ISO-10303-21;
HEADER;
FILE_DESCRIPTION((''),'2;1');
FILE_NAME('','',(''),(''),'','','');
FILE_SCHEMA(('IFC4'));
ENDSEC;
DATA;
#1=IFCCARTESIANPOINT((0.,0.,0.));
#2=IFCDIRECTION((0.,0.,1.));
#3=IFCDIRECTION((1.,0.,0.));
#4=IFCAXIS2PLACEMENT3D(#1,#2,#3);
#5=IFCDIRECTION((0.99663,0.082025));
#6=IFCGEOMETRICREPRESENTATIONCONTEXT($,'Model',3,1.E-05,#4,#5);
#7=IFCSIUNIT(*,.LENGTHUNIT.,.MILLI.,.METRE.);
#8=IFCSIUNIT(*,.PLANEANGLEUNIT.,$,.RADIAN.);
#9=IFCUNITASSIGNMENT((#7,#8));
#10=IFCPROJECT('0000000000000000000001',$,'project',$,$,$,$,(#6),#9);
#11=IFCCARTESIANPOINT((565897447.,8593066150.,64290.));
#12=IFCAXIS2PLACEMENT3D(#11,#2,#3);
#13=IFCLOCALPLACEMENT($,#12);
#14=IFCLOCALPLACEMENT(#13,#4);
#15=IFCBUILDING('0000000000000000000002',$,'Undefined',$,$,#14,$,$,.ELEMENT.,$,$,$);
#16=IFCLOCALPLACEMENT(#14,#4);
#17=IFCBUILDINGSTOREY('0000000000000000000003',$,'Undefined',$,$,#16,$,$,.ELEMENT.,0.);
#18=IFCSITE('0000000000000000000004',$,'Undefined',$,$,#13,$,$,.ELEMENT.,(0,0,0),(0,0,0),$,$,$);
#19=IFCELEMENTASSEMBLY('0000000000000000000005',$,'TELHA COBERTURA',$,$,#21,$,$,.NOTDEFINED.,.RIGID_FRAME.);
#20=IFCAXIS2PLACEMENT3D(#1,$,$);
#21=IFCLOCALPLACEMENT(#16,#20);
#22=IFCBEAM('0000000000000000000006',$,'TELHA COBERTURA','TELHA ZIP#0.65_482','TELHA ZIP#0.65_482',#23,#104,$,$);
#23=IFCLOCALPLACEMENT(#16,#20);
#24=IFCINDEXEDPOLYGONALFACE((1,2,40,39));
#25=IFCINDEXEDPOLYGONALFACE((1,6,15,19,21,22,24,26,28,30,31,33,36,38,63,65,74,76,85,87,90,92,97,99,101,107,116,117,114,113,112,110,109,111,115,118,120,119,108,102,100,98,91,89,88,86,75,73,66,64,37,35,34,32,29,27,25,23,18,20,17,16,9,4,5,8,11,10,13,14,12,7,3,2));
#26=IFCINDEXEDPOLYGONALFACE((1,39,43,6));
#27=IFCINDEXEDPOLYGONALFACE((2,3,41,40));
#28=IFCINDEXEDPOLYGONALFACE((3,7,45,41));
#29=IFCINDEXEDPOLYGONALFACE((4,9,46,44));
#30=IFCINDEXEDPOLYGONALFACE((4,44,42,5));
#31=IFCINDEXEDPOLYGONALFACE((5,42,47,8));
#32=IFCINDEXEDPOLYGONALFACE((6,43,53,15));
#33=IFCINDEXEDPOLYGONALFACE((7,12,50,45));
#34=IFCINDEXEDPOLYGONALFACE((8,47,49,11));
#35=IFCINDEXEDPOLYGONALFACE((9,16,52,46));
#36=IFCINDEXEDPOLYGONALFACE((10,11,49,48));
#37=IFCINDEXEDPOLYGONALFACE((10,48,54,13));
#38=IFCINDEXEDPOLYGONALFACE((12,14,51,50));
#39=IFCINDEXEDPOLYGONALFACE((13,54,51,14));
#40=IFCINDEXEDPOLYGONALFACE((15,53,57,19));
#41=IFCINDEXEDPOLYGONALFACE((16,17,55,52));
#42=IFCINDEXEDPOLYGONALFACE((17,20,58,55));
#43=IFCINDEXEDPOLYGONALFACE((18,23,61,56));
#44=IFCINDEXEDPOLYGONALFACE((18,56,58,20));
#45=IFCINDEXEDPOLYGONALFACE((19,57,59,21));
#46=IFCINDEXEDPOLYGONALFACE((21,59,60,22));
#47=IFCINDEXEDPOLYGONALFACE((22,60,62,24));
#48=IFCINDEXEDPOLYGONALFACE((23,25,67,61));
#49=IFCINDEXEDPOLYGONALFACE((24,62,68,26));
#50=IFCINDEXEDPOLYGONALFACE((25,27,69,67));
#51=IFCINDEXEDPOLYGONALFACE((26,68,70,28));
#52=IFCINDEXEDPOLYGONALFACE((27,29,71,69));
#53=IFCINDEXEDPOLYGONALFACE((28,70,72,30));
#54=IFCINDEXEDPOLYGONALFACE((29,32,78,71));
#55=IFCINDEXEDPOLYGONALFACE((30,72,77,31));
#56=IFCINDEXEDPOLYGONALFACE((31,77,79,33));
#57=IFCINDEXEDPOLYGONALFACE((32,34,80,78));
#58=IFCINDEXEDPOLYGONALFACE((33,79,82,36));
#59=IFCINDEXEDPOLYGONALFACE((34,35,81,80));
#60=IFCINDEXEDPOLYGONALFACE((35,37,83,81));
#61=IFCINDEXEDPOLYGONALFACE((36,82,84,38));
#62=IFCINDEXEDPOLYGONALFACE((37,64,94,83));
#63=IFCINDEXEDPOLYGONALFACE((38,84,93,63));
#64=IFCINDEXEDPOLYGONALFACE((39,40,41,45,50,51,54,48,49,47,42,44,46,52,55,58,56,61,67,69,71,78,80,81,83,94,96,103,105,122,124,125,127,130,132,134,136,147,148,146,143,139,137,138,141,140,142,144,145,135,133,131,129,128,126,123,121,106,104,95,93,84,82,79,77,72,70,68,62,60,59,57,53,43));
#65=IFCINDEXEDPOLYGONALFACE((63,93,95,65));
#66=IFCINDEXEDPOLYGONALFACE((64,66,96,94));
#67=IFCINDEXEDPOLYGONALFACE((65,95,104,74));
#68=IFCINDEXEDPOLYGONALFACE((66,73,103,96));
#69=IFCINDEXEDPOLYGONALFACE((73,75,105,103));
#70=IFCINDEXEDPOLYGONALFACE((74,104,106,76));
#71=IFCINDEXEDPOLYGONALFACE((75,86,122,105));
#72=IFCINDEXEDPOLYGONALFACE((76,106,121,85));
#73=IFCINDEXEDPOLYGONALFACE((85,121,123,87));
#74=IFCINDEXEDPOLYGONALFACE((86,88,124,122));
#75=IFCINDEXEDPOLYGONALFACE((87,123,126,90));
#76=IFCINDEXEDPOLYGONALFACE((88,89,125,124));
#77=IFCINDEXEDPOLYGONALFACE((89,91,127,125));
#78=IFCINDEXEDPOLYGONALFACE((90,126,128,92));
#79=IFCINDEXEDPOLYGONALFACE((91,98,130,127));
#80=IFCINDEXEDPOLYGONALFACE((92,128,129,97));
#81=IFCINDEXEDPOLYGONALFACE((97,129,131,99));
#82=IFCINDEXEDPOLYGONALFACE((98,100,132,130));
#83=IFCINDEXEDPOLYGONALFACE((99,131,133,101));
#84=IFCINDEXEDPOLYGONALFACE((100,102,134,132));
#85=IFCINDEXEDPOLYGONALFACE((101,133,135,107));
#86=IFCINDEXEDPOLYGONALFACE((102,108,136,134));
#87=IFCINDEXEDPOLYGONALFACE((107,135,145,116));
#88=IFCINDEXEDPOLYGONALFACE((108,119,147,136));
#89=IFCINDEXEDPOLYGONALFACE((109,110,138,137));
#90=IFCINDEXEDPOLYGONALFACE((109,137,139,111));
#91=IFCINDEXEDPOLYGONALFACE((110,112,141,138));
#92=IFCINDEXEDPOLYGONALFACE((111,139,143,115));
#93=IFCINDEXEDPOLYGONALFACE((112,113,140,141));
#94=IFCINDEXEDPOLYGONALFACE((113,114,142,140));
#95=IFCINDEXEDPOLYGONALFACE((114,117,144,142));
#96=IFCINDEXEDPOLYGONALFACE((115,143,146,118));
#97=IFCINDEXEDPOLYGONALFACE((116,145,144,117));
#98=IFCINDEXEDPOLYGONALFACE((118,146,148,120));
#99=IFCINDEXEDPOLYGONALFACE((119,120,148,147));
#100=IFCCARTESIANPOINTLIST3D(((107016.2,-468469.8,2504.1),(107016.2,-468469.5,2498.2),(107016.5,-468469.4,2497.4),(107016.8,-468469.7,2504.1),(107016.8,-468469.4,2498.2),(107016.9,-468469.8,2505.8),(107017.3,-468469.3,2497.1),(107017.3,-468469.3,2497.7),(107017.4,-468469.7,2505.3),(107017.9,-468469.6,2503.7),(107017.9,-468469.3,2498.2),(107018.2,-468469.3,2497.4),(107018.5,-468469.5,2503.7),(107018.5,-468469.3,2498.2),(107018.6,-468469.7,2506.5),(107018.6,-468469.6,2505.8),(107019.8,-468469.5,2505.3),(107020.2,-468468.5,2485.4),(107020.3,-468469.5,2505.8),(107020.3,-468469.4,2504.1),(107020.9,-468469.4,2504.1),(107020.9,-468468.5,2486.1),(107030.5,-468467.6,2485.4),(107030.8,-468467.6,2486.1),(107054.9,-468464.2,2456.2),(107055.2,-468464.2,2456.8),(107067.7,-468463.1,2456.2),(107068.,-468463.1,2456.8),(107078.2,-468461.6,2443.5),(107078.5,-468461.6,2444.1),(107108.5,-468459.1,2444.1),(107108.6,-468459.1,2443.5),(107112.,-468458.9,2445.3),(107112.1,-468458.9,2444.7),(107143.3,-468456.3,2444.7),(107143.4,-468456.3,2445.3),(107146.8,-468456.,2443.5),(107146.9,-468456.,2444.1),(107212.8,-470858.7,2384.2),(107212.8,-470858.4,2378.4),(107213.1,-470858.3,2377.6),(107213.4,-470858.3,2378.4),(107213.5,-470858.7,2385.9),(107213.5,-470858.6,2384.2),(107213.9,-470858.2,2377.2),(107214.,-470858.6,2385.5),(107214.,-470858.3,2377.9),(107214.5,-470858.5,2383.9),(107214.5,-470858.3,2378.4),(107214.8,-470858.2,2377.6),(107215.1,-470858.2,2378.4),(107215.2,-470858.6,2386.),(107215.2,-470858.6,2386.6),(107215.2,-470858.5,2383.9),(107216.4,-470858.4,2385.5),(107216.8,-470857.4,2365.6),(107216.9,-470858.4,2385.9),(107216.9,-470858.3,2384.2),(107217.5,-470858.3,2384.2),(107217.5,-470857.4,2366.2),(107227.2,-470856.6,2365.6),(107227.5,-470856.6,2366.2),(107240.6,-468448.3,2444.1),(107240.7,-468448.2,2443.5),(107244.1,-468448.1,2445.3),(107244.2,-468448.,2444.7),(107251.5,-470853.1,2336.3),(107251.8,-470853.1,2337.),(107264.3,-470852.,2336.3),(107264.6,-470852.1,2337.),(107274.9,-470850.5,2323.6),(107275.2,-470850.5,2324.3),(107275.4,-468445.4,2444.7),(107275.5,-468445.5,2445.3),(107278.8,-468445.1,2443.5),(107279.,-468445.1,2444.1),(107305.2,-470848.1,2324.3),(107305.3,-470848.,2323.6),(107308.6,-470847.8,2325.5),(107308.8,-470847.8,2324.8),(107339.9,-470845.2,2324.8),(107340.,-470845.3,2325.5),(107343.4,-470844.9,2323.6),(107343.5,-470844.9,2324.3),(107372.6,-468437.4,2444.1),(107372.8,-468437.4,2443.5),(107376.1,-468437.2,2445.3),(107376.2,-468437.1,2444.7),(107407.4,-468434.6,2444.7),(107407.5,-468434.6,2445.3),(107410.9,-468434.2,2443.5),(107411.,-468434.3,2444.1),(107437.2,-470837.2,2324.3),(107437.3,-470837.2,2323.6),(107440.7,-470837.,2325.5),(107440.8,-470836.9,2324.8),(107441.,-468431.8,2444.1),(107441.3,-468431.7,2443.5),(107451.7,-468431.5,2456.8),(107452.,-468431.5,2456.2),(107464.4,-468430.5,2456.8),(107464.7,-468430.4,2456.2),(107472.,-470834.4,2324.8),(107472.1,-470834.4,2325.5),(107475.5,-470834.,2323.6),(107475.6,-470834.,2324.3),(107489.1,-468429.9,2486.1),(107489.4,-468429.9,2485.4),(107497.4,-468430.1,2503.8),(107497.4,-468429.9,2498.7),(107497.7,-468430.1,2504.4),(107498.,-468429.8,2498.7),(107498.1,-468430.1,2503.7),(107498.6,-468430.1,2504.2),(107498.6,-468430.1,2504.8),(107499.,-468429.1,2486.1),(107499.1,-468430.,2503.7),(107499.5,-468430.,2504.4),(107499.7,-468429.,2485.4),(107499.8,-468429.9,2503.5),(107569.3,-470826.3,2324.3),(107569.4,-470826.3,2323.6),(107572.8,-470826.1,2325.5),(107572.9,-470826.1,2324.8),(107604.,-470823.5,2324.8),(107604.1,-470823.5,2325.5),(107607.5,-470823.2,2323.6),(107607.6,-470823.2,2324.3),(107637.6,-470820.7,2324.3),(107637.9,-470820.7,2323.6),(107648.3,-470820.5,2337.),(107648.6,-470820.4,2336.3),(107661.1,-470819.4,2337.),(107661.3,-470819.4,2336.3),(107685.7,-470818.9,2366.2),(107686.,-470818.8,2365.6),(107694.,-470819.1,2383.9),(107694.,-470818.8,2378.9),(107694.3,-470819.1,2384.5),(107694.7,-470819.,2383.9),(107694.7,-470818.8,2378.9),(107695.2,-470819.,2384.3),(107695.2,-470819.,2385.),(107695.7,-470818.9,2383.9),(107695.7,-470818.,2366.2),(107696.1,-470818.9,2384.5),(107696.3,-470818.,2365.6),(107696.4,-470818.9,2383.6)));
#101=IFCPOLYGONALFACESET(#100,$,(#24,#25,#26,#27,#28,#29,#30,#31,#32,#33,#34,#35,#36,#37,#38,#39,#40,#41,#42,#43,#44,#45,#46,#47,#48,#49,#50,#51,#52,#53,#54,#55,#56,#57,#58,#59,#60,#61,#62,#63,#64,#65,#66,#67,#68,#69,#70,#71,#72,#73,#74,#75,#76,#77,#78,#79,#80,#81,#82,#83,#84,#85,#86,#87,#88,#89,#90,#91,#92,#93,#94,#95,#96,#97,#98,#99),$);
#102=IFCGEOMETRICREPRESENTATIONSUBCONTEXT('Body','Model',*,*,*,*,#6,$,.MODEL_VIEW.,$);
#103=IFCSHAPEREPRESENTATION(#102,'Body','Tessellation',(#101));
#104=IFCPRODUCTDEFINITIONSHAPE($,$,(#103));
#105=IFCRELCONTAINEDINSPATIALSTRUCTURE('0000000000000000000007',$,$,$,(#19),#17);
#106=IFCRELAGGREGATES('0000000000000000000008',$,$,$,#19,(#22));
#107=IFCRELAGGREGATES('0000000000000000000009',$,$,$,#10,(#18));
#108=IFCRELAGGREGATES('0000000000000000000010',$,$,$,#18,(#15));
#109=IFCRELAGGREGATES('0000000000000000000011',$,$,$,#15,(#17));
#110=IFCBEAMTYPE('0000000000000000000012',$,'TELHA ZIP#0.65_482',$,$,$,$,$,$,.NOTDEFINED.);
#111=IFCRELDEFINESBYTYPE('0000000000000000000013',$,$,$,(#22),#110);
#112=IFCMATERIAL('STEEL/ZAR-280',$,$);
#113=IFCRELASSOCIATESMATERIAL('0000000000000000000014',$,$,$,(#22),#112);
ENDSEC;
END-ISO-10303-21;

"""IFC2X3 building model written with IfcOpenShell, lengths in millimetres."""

from ifc_helpers import new_model, si_unit, direction, frame, origin_with_axes, place, context, subcontext, project, spatial, polyline, outline, extrude, material, type_object, element, aggregate, save


model = new_model("IFC2X3")

# Units and contexts
model_context = context("Model", 3, precision=1e-05, world=origin_with_axes(), true_north=direction((0.99663, 0.082025)))
body_context = subcontext(model_context, "Body", "Model", "MODEL_VIEW")
ifc_project = project(units=[si_unit("LENGTHUNIT", "METRE", prefix="MILLI"), si_unit("PLANEANGLEUNIT", "RADIAN")], contexts=[model_context])

# Site, building, storey
site_placement = place(None, frame((565897447.0, 8593066150.0, 64290.0), z_axis=(0.0, 0.0, 1.0), x_axis=(1.0, 0.0, 0.0)))
site = spatial("IfcSite", under=ifc_project, at=site_placement, Name="Undefined", CompositionType="ELEMENT", RefLatitude=(0, 0, 0), RefLongitude=(0, 0, 0))
building_placement = place(site_placement, origin_with_axes())
building = spatial("IfcBuilding", under=site, at=building_placement, Name="Undefined", CompositionType="ELEMENT")
storey_placement = place(building_placement, origin_with_axes())
storey = spatial("IfcBuildingStorey", under=building, at=storey_placement, Name="Undefined", CompositionType="ELEMENT", Elevation=0.0)

# Element assembly, beam
ifc_material_1 = material(Name="STEEL/ZAR-280")
beam_type_1 = type_object("IfcBeamType", Name="TELHA ZIP#0.65_482", PredefinedType="NOTDEFINED")
assembly_1_placement = place(storey_placement, origin_with_axes())
assembly_1 = element("IfcElementAssembly", 1, at=assembly_1_placement, inside=storey, Name="TELHA COBERTURA", AssemblyPlace="NOTDEFINED", PredefinedType="RIGID_FRAME")
beam_1_placement = place(assembly_1_placement, frame((107454.5, -470837.3, 2354.8), z_axis=(0.004096, -0.049769, 0.998752), x_axis=(-0.081923, 0.995387, 0.049938)))
beam_1 = element("IfcBeam", 2, at=beam_1_placement, type_object=beam_type_1, material=ifc_material_1, Name="TELHA COBERTURA", Description="TELHA ZIP#0.65_482", ObjectType="TELHA ZIP#0.65_482", context=body_context, shape_type="SweptSolid", body=[
    extrude(outline(polyline([(240.5, 29.7), (241.4, 30.2), (242.4, 29.7), (242.6, 28.9), (242.6, 10.8), (232.2, 10.8), (207.6, -18.5), (194.9, -18.5), (184.2, -31.2), (153.7, -31.2), (150.2, -30.0), (118.9, -30.0), (115.4, -31.2), (21.2, -31.2), (17.7, -30.0), (-13.6, -30.0), (-17.1, -31.2), (-111.3, -31.2), (-114.8, -30.0), (-146.1, -30.0), (-149.6, -31.2), (-180.1, -31.2), (-190.8, -18.5), (-203.6, -18.5), (-228.1, 10.8), (-238.5, 10.8), (-238.5, 29.5), (-239.0, 30.7), (-240.2, 31.2), (-241.4, 30.7), (-241.9, 29.5), (-241.9, 23.6), (-241.4, 23.1), (-240.9, 23.6), (-240.9, 29.1), (-240.2, 29.1), (-240.2, 23.6), (-240.6, 22.8), (-241.4, 22.4), (-242.3, 22.8), (-242.6, 23.6), (-242.6, 29.5), (-241.9, 31.2), (-240.2, 31.9), (-238.5, 31.2), (-237.9, 29.5), (-237.9, 11.4), (-227.8, 11.4), (-203.2, -17.9), (-190.4, -17.9), (-179.8, -30.5), (-149.7, -30.5), (-146.2, -29.4), (-114.7, -29.4), (-111.2, -30.5), (-17.2, -30.5), (-13.7, -29.4), (17.8, -29.4), (21.3, -30.5), (115.3, -30.5), (118.8, -29.4), (150.3, -29.4), (153.8, -30.5), (183.9, -30.5), (194.6, -17.9), (207.4, -17.9), (231.9, 11.4), (241.9, 11.4), (241.9, 29.1), (241.4, 29.5), (240.9, 29.1), (240.9, 24.1), (240.2, 24.1), (240.2, 29.2), (240.5, 29.7)])), frame((2400.0, 0.0, 0.0), z_axis=(-1.0, 0.0, 0.0), x_axis=(0.0, -1.0, 0.0)), (0.0, 0.0, 1.0), 2400.0),
])
aggregate(assembly_1, [beam_1])

save(model, "model.ifc")
